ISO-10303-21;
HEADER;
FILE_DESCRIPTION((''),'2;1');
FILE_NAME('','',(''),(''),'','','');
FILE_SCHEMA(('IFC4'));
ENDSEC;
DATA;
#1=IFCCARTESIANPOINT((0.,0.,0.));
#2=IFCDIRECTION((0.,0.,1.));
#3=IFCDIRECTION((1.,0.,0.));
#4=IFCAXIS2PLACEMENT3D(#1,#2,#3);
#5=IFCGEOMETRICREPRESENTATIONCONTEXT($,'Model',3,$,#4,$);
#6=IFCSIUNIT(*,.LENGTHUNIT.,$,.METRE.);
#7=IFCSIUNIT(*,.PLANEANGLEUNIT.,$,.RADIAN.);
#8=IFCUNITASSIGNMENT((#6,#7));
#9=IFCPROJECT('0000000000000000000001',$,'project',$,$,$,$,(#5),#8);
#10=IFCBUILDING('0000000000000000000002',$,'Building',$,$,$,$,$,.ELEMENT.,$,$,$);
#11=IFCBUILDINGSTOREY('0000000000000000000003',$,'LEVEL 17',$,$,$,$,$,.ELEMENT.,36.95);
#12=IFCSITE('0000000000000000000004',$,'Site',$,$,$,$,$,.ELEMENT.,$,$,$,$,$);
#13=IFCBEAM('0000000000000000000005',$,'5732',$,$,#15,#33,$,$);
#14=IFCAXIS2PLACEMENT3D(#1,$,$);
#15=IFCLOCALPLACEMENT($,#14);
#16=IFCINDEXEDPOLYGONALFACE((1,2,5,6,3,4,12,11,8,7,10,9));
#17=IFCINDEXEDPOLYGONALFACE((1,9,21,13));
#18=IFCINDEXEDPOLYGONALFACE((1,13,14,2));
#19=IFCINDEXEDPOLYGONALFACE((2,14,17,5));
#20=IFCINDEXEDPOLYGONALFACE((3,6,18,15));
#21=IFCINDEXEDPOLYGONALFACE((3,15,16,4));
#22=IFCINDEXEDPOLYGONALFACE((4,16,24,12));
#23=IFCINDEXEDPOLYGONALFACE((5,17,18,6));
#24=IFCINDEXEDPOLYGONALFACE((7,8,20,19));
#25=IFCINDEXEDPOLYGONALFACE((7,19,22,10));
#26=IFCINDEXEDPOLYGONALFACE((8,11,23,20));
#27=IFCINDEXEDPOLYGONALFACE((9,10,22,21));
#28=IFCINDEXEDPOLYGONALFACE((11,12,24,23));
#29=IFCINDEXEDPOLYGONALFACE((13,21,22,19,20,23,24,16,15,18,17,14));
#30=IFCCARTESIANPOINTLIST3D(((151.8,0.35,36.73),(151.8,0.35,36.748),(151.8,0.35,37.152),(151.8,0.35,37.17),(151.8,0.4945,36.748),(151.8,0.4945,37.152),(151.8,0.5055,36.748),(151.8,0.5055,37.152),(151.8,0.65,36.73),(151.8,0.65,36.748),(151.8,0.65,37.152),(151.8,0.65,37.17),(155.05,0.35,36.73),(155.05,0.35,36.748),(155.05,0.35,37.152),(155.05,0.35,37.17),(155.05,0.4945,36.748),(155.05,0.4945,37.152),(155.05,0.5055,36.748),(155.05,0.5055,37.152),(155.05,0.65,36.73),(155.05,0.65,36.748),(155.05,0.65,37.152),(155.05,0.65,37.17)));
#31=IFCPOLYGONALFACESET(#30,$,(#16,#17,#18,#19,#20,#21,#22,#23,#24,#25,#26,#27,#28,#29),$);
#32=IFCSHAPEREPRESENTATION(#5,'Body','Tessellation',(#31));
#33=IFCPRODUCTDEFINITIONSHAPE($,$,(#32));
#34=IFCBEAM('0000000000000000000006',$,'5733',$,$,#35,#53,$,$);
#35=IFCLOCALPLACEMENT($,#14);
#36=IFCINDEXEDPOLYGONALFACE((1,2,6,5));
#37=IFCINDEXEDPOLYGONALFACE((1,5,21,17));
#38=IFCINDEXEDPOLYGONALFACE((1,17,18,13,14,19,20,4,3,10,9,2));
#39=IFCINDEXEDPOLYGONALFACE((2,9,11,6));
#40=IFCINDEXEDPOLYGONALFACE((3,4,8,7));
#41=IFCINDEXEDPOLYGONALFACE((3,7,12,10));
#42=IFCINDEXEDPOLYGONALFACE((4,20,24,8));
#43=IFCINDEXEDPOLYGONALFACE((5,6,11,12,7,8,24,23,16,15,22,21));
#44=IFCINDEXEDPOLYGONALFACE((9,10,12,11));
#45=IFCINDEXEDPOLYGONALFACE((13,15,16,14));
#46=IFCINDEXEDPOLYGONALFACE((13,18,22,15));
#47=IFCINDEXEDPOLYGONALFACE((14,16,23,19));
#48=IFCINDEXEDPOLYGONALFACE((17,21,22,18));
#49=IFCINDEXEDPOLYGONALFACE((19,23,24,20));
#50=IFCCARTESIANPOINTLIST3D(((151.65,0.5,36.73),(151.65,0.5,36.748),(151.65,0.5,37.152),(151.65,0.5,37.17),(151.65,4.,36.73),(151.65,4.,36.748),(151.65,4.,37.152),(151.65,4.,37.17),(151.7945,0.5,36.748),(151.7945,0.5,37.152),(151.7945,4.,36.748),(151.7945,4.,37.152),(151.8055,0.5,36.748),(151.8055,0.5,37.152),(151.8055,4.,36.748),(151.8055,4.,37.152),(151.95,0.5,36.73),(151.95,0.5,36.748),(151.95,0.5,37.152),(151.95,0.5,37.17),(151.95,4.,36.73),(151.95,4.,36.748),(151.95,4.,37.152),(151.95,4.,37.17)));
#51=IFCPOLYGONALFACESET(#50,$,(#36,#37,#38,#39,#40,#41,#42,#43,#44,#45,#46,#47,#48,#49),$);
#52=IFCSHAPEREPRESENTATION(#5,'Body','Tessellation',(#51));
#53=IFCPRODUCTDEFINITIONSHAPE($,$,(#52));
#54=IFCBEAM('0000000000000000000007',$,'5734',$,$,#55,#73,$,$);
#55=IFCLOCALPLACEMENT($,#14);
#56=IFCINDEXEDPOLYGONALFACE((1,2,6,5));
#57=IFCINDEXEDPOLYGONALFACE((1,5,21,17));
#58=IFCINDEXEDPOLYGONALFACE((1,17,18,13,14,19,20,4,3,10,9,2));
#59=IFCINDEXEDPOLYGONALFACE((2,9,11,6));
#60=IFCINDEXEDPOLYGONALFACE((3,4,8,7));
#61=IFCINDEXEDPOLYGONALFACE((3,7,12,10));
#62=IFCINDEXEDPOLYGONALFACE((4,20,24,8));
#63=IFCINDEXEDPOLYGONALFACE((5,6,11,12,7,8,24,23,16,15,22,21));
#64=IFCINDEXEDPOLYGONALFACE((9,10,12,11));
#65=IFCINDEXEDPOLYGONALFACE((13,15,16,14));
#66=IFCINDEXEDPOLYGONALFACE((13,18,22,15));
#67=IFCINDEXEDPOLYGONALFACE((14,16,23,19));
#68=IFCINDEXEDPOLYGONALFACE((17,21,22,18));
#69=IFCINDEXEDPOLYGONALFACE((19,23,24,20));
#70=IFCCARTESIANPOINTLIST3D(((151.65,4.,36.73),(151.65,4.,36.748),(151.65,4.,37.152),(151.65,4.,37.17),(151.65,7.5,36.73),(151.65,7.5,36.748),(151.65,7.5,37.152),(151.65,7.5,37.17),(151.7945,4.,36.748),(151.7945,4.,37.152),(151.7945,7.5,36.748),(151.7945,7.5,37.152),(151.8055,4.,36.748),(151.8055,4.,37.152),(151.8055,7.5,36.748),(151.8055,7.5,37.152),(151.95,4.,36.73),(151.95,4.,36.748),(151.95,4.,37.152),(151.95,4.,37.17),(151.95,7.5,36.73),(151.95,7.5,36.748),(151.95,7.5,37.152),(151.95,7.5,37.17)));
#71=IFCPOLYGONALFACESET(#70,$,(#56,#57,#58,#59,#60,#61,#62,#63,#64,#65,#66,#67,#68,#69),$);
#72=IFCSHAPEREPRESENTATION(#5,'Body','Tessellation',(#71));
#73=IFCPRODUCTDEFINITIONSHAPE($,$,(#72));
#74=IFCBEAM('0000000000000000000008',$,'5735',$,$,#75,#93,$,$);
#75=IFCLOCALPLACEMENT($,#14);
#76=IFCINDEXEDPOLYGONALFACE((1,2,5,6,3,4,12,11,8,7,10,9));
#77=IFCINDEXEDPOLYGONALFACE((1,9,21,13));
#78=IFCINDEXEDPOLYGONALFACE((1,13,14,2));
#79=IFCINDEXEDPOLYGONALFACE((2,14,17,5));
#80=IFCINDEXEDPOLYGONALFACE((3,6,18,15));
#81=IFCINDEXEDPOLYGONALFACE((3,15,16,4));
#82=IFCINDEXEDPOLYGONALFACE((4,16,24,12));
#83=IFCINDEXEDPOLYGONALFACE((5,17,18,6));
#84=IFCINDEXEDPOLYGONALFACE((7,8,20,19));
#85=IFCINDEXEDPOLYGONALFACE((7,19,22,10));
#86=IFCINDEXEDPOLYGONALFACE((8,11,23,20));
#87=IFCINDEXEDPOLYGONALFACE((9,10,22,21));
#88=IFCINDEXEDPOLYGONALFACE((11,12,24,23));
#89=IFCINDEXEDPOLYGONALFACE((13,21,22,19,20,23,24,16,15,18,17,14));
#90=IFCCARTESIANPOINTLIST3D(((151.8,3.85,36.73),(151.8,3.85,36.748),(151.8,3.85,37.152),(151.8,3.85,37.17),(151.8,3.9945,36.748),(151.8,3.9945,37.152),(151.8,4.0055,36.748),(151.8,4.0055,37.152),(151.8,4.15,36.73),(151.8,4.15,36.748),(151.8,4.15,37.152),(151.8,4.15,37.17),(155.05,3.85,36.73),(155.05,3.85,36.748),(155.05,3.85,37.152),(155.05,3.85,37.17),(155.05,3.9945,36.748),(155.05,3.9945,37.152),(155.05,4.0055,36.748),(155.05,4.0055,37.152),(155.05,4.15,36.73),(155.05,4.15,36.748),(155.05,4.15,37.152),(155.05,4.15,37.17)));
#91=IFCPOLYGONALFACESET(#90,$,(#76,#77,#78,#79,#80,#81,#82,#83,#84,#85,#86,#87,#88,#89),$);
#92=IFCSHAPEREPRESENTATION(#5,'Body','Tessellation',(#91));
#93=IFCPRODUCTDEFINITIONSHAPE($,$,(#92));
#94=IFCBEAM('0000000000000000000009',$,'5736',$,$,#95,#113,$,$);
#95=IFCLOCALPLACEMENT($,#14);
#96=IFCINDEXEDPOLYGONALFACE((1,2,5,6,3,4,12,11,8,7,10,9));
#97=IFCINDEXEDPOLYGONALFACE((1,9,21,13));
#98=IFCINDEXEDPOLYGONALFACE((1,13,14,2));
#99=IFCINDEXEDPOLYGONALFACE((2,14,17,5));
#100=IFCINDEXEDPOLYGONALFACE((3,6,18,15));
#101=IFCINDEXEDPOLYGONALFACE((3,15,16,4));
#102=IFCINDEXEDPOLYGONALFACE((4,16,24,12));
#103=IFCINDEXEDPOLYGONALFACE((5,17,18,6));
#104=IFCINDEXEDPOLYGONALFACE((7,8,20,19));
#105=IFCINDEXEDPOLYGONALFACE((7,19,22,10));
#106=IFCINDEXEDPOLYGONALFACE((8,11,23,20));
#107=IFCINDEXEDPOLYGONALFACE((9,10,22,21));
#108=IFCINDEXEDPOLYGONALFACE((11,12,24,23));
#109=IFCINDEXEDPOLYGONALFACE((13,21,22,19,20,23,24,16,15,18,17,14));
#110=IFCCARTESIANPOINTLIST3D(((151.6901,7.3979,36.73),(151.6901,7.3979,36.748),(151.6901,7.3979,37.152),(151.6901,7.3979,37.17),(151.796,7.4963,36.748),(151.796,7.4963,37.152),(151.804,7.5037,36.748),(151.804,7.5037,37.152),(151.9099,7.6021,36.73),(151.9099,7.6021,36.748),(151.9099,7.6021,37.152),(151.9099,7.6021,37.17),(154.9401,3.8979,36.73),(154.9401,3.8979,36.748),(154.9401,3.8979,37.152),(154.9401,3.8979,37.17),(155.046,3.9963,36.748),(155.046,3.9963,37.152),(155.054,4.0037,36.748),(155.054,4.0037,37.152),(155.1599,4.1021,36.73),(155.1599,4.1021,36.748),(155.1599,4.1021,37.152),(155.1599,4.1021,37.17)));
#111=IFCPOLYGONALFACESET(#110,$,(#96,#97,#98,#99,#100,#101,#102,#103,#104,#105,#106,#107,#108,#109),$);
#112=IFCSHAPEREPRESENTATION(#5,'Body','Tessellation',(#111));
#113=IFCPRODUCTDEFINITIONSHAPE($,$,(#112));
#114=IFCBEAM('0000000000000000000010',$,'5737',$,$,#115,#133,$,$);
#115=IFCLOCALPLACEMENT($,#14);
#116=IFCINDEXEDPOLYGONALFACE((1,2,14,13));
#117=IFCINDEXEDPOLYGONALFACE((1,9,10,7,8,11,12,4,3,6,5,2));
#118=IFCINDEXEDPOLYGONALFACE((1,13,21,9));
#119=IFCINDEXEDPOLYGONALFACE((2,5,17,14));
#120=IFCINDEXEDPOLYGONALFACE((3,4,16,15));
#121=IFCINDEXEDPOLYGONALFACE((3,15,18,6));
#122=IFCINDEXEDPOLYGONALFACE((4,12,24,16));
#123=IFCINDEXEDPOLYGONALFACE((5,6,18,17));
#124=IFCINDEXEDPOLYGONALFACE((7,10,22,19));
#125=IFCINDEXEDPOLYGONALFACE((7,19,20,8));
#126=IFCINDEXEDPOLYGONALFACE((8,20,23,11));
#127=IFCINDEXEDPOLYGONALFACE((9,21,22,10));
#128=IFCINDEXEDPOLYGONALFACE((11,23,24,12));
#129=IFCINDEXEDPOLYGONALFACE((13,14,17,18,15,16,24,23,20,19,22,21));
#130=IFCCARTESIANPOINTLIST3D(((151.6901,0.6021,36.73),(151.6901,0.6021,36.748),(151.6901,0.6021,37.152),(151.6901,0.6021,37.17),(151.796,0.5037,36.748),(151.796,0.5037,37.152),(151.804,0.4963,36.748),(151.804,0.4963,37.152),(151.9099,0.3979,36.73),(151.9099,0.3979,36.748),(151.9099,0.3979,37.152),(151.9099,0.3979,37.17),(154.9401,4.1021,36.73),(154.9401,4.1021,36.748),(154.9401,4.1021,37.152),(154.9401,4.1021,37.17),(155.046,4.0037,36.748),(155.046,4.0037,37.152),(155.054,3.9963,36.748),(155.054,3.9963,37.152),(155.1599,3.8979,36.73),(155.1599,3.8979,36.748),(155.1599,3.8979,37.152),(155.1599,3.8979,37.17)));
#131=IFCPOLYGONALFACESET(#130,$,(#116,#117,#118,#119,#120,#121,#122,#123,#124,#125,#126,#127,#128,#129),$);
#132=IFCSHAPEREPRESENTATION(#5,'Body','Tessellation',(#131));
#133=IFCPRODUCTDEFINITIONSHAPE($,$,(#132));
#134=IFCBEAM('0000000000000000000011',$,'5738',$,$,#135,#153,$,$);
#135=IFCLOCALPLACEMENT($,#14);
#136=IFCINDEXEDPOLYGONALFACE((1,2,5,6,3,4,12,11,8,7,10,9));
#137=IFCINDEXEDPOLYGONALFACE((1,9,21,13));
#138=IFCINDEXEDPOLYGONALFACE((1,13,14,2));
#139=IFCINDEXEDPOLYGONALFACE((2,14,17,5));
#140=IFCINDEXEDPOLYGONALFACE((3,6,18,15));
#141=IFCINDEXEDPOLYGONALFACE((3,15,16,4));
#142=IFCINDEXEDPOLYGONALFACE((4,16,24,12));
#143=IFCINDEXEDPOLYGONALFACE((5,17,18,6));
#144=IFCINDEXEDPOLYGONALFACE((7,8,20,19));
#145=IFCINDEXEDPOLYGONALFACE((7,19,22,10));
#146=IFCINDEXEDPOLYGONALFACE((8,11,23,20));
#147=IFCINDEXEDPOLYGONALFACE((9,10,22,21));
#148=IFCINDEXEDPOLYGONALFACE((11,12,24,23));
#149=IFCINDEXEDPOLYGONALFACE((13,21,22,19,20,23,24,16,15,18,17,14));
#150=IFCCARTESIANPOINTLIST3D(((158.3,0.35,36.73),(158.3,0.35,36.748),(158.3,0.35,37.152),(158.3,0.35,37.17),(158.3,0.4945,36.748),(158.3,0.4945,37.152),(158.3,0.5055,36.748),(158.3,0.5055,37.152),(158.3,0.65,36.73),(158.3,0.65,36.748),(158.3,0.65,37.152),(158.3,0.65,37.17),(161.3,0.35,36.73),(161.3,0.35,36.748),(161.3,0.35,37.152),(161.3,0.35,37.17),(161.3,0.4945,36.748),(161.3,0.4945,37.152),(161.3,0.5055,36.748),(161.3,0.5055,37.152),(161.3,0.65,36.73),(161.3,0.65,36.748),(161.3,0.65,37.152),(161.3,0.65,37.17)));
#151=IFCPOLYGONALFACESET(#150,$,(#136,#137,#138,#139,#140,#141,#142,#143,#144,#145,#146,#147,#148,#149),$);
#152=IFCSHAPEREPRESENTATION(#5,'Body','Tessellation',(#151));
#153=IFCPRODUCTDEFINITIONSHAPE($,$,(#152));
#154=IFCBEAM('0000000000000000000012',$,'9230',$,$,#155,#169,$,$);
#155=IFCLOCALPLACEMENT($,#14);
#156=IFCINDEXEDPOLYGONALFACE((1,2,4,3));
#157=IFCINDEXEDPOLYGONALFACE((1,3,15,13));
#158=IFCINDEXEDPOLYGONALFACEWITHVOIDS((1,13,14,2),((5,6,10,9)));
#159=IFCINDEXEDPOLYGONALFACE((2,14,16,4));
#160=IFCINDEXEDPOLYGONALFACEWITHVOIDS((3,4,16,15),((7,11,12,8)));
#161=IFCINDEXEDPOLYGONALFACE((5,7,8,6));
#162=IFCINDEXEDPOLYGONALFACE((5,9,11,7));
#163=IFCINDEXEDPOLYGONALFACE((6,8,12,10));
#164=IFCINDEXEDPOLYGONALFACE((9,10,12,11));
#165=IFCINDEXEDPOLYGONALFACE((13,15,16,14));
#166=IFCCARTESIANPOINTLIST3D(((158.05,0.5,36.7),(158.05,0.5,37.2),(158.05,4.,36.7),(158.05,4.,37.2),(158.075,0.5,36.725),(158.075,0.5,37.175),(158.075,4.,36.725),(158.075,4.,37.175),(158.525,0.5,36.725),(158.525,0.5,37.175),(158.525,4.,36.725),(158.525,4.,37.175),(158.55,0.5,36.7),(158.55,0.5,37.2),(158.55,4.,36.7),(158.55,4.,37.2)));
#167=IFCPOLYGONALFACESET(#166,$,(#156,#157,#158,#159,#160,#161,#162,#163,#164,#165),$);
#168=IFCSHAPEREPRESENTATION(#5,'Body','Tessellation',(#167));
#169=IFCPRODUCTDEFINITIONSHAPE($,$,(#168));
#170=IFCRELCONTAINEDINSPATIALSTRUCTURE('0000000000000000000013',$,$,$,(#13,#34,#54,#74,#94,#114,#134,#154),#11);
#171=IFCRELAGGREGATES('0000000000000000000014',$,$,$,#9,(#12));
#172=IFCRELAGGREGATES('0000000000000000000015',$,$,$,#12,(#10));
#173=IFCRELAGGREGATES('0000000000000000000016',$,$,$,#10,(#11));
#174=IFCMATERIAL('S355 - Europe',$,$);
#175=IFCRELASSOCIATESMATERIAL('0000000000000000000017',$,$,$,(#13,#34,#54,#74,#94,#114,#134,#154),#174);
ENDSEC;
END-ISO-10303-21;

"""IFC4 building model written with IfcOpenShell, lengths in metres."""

from ifc_helpers import new_model, si_unit, frame, origin_with_axes, origin_2d_with_axis, place, context, project, spatial, hollow_rectangle, i_section, extrude, material, material_profile, profile_set, profile_usage, element, save


model = new_model("IFC4")

# Units and contexts
model_context = context("Model", 3, world=origin_with_axes())
ifc_project = project(units=[si_unit("LENGTHUNIT", "METRE"), si_unit("PLANEANGLEUNIT", "RADIAN")], contexts=[model_context])

# Site, building, storey
site = spatial("IfcSite", under=ifc_project, Name="Site", CompositionType="ELEMENT")
building = spatial("IfcBuilding", under=site, Name="Building", CompositionType="ELEMENT")
storey = spatial("IfcBuildingStorey", under=building, Name="LEVEL 17", CompositionType="ELEMENT", Elevation=36.95)

# Shared definitions
ifc_material = material(Name="S355 - Europe")

# Beams
ifc_material_profile_1 = material_profile(ifc_material, i_section(OverallWidth=0.3, OverallDepth=0.44, WebThickness=0.011, FlangeThickness=0.018, at=origin_2d_with_axis()))
ifc_profile_set_1 = profile_set([ifc_material_profile_1])
ifc_profile_usage_1 = profile_usage(ifc_profile_set_1, cardinal=10)
beam_1_placement = place(None, frame((155.05, 0.5, 36.95), z_axis=(-1.0, 0.0, 0.0), x_axis=(0.0, -1.0, 0.0)))
element("IfcBeam", 1, at=beam_1_placement, inside=storey, material=ifc_profile_usage_1, Name="5732", context=model_context, shape_type="SweptSolid", body=[
    extrude(i_section(OverallWidth=0.3, OverallDepth=0.44, WebThickness=0.011, FlangeThickness=0.018, at=origin_2d_with_axis()), origin_with_axes(), (0.0, 0.0, 1.0), 3.25),
])
ifc_material_profile_2 = material_profile(ifc_material, i_section(OverallWidth=0.3, OverallDepth=0.44, WebThickness=0.011, FlangeThickness=0.018, at=origin_2d_with_axis()))
ifc_profile_set_2 = profile_set([ifc_material_profile_2])
ifc_profile_usage_2 = profile_usage(ifc_profile_set_2, cardinal=10)
beam_2_placement = place(None, frame((151.8, 0.5, 36.95), z_axis=(0.0, 1.0, 0.0), x_axis=(-1.0, 0.0, 0.0)))
element("IfcBeam", 2, at=beam_2_placement, inside=storey, material=ifc_profile_usage_2, Name="5733", context=model_context, shape_type="SweptSolid", body=[
    extrude(i_section(OverallWidth=0.3, OverallDepth=0.44, WebThickness=0.011, FlangeThickness=0.018, at=origin_2d_with_axis()), origin_with_axes(), (0.0, 0.0, 1.0), 3.5),
])
ifc_material_profile_3 = material_profile(ifc_material, i_section(OverallWidth=0.3, OverallDepth=0.44, WebThickness=0.011, FlangeThickness=0.018, at=origin_2d_with_axis()))
ifc_profile_set_3 = profile_set([ifc_material_profile_3])
ifc_profile_usage_3 = profile_usage(ifc_profile_set_3, cardinal=10)
beam_3_placement = place(None, frame((151.8, 4.0, 36.95), z_axis=(0.0, 1.0, 0.0), x_axis=(-1.0, 0.0, 0.0)))
element("IfcBeam", 3, at=beam_3_placement, inside=storey, material=ifc_profile_usage_3, Name="5734", context=model_context, shape_type="SweptSolid", body=[
    extrude(i_section(OverallWidth=0.3, OverallDepth=0.44, WebThickness=0.011, FlangeThickness=0.018, at=origin_2d_with_axis()), origin_with_axes(), (0.0, 0.0, 1.0), 3.5),
])
ifc_material_profile_4 = material_profile(ifc_material, i_section(OverallWidth=0.3, OverallDepth=0.44, WebThickness=0.011, FlangeThickness=0.018, at=origin_2d_with_axis()))
ifc_profile_set_4 = profile_set([ifc_material_profile_4])
ifc_profile_usage_4 = profile_usage(ifc_profile_set_4, cardinal=10)
beam_4_placement = place(None, frame((151.8, 4.0, 36.95), z_axis=(1.0, 0.0, 0.0), x_axis=(0.0, 1.0, 0.0)))
element("IfcBeam", 4, at=beam_4_placement, inside=storey, material=ifc_profile_usage_4, Name="5735", context=model_context, shape_type="SweptSolid", body=[
    extrude(i_section(OverallWidth=0.3, OverallDepth=0.44, WebThickness=0.011, FlangeThickness=0.018, at=origin_2d_with_axis()), origin_with_axes(), (0.0, 0.0, 1.0), 3.25),
])
ifc_material_profile_5 = material_profile(ifc_material, i_section(OverallWidth=0.3, OverallDepth=0.44, WebThickness=0.011, FlangeThickness=0.018, at=origin_2d_with_axis()))
ifc_profile_set_5 = profile_set([ifc_material_profile_5])
ifc_profile_usage_5 = profile_usage(ifc_profile_set_5, cardinal=10)
beam_5_placement = place(None, frame((155.05, 4.0, 36.95), z_axis=(-0.680451, 0.732793, 0.0), x_axis=(-0.732793, -0.680451, 0.0)))
element("IfcBeam", 5, at=beam_5_placement, inside=storey, material=ifc_profile_usage_5, Name="5736", context=model_context, shape_type="SweptSolid", body=[
    extrude(i_section(OverallWidth=0.3, OverallDepth=0.44, WebThickness=0.011, FlangeThickness=0.018, at=origin_2d_with_axis()), origin_with_axes(), (0.0, 0.0, 1.0), 4.7762),
])
ifc_material_profile_6 = material_profile(ifc_material, i_section(OverallWidth=0.3, OverallDepth=0.44, WebThickness=0.011, FlangeThickness=0.018, at=origin_2d_with_axis()))
ifc_profile_set_6 = profile_set([ifc_material_profile_6])
ifc_profile_usage_6 = profile_usage(ifc_profile_set_6, cardinal=10)
beam_6_placement = place(None, frame((155.05, 4.0, 36.95), z_axis=(-0.680451, -0.732793, 0.0), x_axis=(0.732793, -0.680451, 0.0)))
element("IfcBeam", 6, at=beam_6_placement, inside=storey, material=ifc_profile_usage_6, Name="5737", context=model_context, shape_type="SweptSolid", body=[
    extrude(i_section(OverallWidth=0.3, OverallDepth=0.44, WebThickness=0.011, FlangeThickness=0.018, at=origin_2d_with_axis()), origin_with_axes(), (0.0, 0.0, 1.0), 4.7762),
])
ifc_material_profile_7 = material_profile(ifc_material, i_section(OverallWidth=0.3, OverallDepth=0.44, WebThickness=0.011, FlangeThickness=0.018, at=origin_2d_with_axis()))
ifc_profile_set_7 = profile_set([ifc_material_profile_7])
ifc_profile_usage_7 = profile_usage(ifc_profile_set_7, cardinal=10)
beam_7_placement = place(None, frame((158.3, 0.5, 36.95), z_axis=(1.0, 0.0, 0.0), x_axis=(0.0, 1.0, 0.0)))
element("IfcBeam", 7, at=beam_7_placement, inside=storey, material=ifc_profile_usage_7, Name="5738", context=model_context, shape_type="SweptSolid", body=[
    extrude(i_section(OverallWidth=0.3, OverallDepth=0.44, WebThickness=0.011, FlangeThickness=0.018, at=origin_2d_with_axis()), origin_with_axes(), (0.0, 0.0, 1.0), 3.0),
])
ifc_material_profile_8 = material_profile(ifc_material, hollow_rectangle(XDim=0.5, YDim=0.5, WallThickness=0.025, at=origin_2d_with_axis()))
ifc_profile_set_8 = profile_set([ifc_material_profile_8])
ifc_profile_usage_8 = profile_usage(ifc_profile_set_8, cardinal=10)
beam_8_placement = place(None, frame((158.3, 4.0, 36.95), z_axis=(0.0, -1.0, 0.0), x_axis=(1.0, 0.0, 0.0)))
element("IfcBeam", 8, at=beam_8_placement, inside=storey, material=ifc_profile_usage_8, Name="9230", context=model_context, shape_type="SweptSolid", body=[
    extrude(hollow_rectangle(XDim=0.5, YDim=0.5, WallThickness=0.025, at=origin_2d_with_axis()), origin_with_axes(), (0.0, 0.0, 1.0), 3.5),
])

save(model, "model.ifc")
